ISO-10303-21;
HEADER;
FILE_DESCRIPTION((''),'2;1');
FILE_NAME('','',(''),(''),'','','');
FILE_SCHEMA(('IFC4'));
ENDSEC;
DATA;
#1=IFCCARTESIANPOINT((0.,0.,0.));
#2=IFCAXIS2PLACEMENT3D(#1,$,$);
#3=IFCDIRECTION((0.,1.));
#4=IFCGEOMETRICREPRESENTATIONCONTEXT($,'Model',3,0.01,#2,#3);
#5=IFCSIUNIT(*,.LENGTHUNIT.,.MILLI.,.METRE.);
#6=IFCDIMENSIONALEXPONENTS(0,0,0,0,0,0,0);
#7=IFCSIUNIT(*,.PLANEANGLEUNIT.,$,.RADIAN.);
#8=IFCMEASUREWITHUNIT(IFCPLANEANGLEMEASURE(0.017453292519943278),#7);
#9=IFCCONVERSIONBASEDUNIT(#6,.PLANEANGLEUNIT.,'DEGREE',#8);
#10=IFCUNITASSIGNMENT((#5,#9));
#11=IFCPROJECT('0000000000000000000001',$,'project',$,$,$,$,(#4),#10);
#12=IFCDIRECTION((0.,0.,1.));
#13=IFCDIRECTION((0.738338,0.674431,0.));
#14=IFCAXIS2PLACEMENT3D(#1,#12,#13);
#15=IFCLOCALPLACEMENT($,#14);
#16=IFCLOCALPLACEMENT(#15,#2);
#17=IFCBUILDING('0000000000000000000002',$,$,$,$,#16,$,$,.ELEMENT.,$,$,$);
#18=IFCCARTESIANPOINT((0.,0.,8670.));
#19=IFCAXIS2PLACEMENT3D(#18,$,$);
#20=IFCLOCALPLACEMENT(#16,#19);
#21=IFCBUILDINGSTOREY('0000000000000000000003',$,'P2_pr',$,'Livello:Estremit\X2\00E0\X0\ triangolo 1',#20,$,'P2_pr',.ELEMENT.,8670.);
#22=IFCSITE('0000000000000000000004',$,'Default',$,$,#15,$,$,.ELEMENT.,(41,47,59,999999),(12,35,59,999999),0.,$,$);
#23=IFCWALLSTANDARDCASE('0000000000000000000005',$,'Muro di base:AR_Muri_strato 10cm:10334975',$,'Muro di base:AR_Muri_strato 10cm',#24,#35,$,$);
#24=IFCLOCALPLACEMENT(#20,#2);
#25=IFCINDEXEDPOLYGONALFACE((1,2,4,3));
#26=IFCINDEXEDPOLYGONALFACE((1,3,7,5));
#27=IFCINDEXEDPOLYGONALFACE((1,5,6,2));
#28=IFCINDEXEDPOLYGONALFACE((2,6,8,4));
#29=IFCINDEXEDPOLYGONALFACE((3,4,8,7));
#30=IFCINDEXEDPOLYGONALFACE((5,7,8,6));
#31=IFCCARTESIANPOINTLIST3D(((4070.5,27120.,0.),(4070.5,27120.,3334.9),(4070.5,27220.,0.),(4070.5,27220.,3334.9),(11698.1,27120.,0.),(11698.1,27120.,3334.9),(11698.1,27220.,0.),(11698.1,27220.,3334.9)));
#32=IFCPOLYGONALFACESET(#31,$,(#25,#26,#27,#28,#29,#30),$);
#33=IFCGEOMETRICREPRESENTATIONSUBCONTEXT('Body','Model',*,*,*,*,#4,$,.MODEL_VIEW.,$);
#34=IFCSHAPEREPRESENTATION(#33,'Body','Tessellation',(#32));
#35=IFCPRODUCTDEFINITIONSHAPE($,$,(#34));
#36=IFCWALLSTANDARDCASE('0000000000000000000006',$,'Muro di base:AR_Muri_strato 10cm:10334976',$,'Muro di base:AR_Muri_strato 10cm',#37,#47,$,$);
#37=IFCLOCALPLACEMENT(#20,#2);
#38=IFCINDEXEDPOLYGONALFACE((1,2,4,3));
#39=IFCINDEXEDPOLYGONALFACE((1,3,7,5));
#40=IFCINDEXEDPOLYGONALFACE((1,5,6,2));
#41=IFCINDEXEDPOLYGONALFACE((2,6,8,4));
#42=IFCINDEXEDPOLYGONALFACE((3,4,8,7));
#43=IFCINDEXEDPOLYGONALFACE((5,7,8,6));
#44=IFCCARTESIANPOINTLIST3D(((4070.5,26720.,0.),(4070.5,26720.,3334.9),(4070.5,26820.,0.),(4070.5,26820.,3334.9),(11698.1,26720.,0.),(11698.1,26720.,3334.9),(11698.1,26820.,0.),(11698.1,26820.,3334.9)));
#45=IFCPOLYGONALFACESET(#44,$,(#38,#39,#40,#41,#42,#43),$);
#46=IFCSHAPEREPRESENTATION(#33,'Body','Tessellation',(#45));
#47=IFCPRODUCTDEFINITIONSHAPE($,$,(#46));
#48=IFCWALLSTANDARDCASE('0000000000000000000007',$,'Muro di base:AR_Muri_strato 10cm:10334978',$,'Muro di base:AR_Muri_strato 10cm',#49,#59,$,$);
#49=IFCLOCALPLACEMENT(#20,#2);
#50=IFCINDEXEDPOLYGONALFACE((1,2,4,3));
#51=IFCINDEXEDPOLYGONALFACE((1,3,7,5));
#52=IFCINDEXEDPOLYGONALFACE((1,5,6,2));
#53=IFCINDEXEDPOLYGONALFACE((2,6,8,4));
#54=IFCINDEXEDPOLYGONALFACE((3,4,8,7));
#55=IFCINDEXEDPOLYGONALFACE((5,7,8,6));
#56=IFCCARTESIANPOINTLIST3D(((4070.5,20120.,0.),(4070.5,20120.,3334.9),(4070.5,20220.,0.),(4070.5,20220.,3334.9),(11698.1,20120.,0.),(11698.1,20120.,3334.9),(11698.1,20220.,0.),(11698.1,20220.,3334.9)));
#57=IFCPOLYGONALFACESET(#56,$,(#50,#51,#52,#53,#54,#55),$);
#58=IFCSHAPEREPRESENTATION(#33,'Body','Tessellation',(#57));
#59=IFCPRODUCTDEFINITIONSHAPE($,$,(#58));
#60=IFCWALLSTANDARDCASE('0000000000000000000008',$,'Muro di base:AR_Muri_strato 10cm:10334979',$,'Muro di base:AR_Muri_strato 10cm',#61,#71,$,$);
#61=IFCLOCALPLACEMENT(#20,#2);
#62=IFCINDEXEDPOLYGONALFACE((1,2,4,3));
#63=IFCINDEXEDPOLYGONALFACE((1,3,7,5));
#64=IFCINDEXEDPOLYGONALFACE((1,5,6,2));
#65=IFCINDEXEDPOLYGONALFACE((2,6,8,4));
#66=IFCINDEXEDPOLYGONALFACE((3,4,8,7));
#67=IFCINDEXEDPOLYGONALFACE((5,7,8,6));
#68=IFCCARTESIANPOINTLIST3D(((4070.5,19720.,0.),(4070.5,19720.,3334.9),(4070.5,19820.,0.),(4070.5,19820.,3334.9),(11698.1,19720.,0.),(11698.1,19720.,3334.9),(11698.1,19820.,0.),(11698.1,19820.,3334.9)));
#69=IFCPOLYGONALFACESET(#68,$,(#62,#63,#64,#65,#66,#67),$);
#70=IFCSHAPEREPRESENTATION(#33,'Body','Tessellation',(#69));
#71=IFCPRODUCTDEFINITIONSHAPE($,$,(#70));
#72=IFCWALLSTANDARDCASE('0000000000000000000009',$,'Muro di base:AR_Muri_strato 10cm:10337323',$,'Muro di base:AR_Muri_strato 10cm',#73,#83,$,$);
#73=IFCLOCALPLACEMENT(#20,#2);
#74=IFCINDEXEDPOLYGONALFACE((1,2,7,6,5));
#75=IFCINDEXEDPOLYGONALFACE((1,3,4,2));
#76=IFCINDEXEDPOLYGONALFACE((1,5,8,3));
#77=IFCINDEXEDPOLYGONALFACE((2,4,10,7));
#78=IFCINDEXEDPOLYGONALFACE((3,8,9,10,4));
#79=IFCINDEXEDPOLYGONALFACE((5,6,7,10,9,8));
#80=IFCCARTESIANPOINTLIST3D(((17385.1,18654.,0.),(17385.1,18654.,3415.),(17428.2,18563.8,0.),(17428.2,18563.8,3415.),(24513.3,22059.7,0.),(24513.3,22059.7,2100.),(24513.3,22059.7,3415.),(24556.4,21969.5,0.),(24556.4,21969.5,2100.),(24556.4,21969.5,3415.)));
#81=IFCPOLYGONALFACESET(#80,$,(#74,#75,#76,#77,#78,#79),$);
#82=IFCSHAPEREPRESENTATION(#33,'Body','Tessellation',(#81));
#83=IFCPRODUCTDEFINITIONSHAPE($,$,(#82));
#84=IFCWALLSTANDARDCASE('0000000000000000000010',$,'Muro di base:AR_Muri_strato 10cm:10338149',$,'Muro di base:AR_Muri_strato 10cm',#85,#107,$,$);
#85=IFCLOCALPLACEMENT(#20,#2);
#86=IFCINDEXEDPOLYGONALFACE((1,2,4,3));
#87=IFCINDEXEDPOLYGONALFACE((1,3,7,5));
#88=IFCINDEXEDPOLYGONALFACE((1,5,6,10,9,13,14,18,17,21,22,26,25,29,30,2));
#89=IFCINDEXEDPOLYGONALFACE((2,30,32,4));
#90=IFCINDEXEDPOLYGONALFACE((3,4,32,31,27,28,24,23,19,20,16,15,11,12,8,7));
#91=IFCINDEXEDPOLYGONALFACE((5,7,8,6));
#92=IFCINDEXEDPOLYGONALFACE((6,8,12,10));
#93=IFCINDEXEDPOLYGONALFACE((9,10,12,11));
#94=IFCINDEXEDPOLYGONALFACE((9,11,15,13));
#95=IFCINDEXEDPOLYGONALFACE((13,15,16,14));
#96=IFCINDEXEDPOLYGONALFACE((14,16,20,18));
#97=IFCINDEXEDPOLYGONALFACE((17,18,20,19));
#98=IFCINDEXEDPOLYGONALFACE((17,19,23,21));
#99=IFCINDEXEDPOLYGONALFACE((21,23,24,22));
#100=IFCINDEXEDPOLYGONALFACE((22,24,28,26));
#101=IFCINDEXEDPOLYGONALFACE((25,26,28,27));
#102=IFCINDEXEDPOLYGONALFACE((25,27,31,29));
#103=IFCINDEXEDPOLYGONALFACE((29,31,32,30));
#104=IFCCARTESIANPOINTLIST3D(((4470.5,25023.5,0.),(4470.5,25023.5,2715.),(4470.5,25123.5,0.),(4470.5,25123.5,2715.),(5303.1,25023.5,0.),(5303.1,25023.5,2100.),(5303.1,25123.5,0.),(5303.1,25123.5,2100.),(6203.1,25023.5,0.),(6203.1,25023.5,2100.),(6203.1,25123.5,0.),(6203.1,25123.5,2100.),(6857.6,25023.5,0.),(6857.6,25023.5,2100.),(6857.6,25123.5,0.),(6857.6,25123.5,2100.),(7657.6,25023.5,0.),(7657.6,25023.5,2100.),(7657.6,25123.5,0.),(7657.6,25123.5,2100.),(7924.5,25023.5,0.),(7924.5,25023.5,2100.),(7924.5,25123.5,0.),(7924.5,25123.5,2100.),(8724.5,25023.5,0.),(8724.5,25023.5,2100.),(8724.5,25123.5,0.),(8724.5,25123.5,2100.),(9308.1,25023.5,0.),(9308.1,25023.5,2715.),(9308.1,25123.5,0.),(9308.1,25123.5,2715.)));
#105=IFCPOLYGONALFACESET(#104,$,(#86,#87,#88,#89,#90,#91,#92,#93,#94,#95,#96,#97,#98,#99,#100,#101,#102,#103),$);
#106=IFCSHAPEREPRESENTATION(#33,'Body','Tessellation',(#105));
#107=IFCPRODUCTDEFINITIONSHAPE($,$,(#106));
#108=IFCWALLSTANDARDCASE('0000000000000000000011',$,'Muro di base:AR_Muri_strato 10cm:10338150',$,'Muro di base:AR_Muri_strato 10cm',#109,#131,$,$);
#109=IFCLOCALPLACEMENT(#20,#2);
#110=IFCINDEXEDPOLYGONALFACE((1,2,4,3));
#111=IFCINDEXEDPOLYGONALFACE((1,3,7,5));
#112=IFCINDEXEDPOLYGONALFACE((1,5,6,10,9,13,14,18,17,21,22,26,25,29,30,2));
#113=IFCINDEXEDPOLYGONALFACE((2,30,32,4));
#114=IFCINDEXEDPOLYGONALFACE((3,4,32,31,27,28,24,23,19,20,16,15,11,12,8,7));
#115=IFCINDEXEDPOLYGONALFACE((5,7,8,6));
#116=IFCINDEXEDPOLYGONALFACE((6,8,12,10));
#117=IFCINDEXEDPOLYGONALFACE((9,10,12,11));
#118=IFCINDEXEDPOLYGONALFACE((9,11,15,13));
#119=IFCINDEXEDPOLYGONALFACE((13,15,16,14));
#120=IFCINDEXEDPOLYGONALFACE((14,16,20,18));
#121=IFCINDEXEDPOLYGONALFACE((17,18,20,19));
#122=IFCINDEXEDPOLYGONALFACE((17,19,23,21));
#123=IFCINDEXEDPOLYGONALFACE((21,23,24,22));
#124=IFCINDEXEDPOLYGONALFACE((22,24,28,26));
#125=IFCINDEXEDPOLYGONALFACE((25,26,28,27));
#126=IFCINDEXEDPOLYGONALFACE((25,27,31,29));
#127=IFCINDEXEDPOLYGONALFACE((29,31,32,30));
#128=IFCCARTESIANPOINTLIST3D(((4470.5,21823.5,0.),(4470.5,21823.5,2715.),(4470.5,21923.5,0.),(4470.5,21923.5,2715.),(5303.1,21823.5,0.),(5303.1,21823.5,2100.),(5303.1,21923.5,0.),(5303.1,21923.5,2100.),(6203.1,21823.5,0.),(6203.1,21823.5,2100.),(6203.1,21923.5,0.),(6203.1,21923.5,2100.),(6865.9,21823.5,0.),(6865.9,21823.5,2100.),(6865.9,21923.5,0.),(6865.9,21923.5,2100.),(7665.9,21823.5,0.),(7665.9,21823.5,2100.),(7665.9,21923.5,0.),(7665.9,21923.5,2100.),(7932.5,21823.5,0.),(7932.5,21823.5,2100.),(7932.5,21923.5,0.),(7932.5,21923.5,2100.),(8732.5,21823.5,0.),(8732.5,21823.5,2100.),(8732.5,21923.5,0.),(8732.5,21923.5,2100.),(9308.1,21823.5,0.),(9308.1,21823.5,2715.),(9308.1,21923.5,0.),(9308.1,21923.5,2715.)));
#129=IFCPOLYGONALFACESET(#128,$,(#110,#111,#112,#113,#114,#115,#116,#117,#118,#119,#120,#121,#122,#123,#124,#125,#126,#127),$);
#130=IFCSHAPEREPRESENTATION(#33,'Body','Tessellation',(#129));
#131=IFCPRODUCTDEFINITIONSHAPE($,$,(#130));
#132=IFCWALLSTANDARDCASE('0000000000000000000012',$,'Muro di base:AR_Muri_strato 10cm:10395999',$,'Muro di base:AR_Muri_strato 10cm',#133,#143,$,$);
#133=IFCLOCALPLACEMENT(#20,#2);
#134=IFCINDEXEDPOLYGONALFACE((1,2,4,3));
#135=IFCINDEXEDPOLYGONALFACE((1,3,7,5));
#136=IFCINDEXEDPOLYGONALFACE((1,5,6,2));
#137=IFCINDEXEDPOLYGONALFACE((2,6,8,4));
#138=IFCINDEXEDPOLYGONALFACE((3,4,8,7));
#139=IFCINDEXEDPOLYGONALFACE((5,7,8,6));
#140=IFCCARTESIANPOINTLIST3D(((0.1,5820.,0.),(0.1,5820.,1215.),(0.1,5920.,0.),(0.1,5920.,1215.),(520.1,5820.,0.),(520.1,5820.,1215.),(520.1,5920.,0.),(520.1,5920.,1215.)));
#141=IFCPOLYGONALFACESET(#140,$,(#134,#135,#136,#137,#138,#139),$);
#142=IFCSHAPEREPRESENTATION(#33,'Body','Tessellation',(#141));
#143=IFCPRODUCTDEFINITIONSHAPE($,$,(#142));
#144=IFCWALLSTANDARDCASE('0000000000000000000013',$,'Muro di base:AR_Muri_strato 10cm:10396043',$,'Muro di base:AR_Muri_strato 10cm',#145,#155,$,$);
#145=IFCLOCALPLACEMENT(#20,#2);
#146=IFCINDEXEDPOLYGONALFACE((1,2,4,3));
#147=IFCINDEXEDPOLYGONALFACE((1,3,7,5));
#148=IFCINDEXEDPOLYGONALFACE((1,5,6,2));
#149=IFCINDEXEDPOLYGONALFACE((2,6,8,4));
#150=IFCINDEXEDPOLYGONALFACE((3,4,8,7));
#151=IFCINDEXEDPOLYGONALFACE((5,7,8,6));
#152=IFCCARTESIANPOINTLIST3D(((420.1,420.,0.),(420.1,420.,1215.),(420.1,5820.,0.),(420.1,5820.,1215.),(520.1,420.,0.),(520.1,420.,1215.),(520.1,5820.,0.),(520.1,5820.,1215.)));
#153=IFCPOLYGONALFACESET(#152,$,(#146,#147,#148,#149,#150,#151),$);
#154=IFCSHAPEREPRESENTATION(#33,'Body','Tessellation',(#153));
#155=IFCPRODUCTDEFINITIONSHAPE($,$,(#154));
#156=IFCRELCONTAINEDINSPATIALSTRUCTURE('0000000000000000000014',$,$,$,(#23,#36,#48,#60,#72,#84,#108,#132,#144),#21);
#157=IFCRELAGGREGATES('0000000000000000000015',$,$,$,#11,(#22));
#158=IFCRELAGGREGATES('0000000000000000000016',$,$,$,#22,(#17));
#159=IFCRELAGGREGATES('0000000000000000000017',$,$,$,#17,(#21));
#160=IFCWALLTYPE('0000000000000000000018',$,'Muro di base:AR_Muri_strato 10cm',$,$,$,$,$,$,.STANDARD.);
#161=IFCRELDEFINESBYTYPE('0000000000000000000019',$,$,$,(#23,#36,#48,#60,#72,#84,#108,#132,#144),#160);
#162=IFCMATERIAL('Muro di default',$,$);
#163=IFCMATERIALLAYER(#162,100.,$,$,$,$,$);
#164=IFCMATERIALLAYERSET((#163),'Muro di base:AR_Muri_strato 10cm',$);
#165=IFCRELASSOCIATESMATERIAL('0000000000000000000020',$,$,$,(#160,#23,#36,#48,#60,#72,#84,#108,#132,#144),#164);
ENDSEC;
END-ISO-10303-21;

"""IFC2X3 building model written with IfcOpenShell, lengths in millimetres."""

from ifc_helpers import new_model, entity, si_unit, converted_unit, direction, frame, frame_2d, origin, origin_2d_with_axis, place, context, subcontext, project, spatial, rectangle, extrude, material, layer, layer_set, layer_usage, type_object, element, save


model = new_model("IFC2X3")

# Units and contexts
model_context = context("Model", 3, precision=0.01, world=origin(), true_north=direction((0.0, 1.0)))
body_context = subcontext(model_context, "Body", "Model", "MODEL_VIEW")
ifc_project = project(units=[si_unit("LENGTHUNIT", "METRE", prefix="MILLI"), converted_unit("PLANEANGLEUNIT", "DEGREE", entity("IfcPlaneAngleMeasure", 0.017453292519943278), si_unit("PLANEANGLEUNIT", "RADIAN"), dimensions=[0, 0, 0, 0, 0, 0, 0])], contexts=[model_context])

# Site, building, storey
site_placement = place(None, frame((0.0, 0.0, 0.0), z_axis=(0.0, 0.0, 1.0), x_axis=(0.738338, 0.674431, 0.0)))
site = spatial("IfcSite", under=ifc_project, at=site_placement, Name="Default", CompositionType="ELEMENT", RefLatitude=(41, 47, 59, 999999), RefLongitude=(12, 35, 59, 999999), RefElevation=0.0)
building_placement = place(site_placement, origin())
building = spatial("IfcBuilding", under=site, at=building_placement, CompositionType="ELEMENT")
storey_placement = place(building_placement, frame((0.0, 0.0, 8670.0)))
storey = spatial("IfcBuildingStorey", under=building, at=storey_placement, Name="P2_pr", ObjectType="Livello:Estremità triangolo 1", LongName="P2_pr", CompositionType="ELEMENT", Elevation=8670.0)

# Walls
ifc_material = material(Name="Muro di default")
ifc_layer_1 = layer(ifc_material, 100.0)
ifc_layer_set_1 = layer_set([ifc_layer_1], Name="Muro di base:AR_Muri_strato 10cm")
ifc_layer_usage_1 = layer_usage(ifc_layer_set_1, "AXIS2", "NEGATIVE", 50.0)
wall_type_1 = type_object("IfcWallType", Name="Muro di base:AR_Muri_strato 10cm", PredefinedType="STANDARD", material=ifc_layer_set_1)
wall_1_placement = place(storey_placement, frame((4070.5, 27170.0, 0.0)))
element("IfcWallStandardCase", 1, at=wall_1_placement, inside=storey, type_object=wall_type_1, material=ifc_layer_usage_1, Name="Muro di base:AR_Muri_strato 10cm:10334975", ObjectType="Muro di base:AR_Muri_strato 10cm", context=body_context, shape_type="SweptSolid", body=[
    extrude(rectangle(XDim=7627.6, YDim=100.0, at=frame_2d((3813.8, 0.0), x_axis=(-1.0, 0.0))), origin(), (0.0, 0.0, 1.0), 3334.9),
])
ifc_layer_usage_2 = layer_usage(ifc_layer_set_1, "AXIS2", "POSITIVE", -50.0)
wall_2_placement = place(storey_placement, frame((4070.5, 26770.0, 0.0)))
element("IfcWallStandardCase", 2, at=wall_2_placement, inside=storey, type_object=wall_type_1, material=ifc_layer_usage_2, Name="Muro di base:AR_Muri_strato 10cm:10334976", ObjectType="Muro di base:AR_Muri_strato 10cm", context=body_context, shape_type="SweptSolid", body=[
    extrude(rectangle(XDim=7627.6, YDim=100.0, at=frame_2d((3813.8, 0.0), x_axis=(-1.0, 0.0))), origin(), (0.0, 0.0, 1.0), 3334.9),
])
ifc_layer_usage_3 = layer_usage(ifc_layer_set_1, "AXIS2", "NEGATIVE", 50.0)
wall_3_placement = place(storey_placement, frame((4070.5, 20170.0, 0.0)))
element("IfcWallStandardCase", 3, at=wall_3_placement, inside=storey, type_object=wall_type_1, material=ifc_layer_usage_3, Name="Muro di base:AR_Muri_strato 10cm:10334978", ObjectType="Muro di base:AR_Muri_strato 10cm", context=body_context, shape_type="SweptSolid", body=[
    extrude(rectangle(XDim=7627.6, YDim=100.0, at=frame_2d((3813.8, 0.0), x_axis=(-1.0, 0.0))), origin(), (0.0, 0.0, 1.0), 3334.9),
])
ifc_layer_usage_4 = layer_usage(ifc_layer_set_1, "AXIS2", "POSITIVE", -50.0)
wall_4_placement = place(storey_placement, frame((4070.5, 19770.0, 0.0)))
element("IfcWallStandardCase", 4, at=wall_4_placement, inside=storey, type_object=wall_type_1, material=ifc_layer_usage_4, Name="Muro di base:AR_Muri_strato 10cm:10334979", ObjectType="Muro di base:AR_Muri_strato 10cm", context=body_context, shape_type="SweptSolid", body=[
    extrude(rectangle(XDim=7627.6, YDim=100.0, at=frame_2d((3813.8, 0.0), x_axis=(-1.0, 0.0))), origin(), (0.0, 0.0, 1.0), 3334.9),
])

# Wall, opening
ifc_layer_usage_5 = layer_usage(ifc_layer_set_1, "AXIS2", "POSITIVE", -50.0)
wall_5_placement = place(storey_placement, frame((24534.8, 22014.6, 0.0), z_axis=(0.0, 0.0, 1.0), x_axis=(-0.902302, -0.431105, 0.0)))
wall_5 = element("IfcWallStandardCase", 5, at=wall_5_placement, inside=storey, type_object=wall_type_1, material=ifc_layer_usage_5, Name="Muro di base:AR_Muri_strato 10cm:10337323", ObjectType="Muro di base:AR_Muri_strato 10cm", context=body_context, shape_type="SweptSolid", body=[
    extrude(rectangle(XDim=7900.0, YDim=100.0, at=frame_2d((3950.0, 0.0), x_axis=(-1.0, 0.0))), origin(), (0.0, 0.0, 1.0), 3415.0),
])
opening_1_placement = place(wall_5_placement, origin())
element("IfcOpeningElement", 6, at=opening_1_placement, cuts=wall_5, ObjectType="Opening", context=body_context, shape_type="SweptSolid", body=[
    extrude(rectangle(XDim=2100.0, YDim=1100.0, at=frame_2d((0.0, 0.0), x_axis=(0.0, 1.0))), frame((-550.0, -1874.0, 1050.0), z_axis=(0.000006, 1.0, 0.0), x_axis=(1.0, -0.000006, 0.0)), (0.0, 0.0, 1.0), 3048.0),
])

# Walls, openings
ifc_layer_usage_6 = layer_usage(ifc_layer_set_1, "AXIS2", "NEGATIVE", 50.0)
wall_6_placement = place(storey_placement, frame((4470.5, 25073.5, 0.0)))
wall_6 = element("IfcWallStandardCase", 7, at=wall_6_placement, inside=storey, type_object=wall_type_1, material=ifc_layer_usage_6, Name="Muro di base:AR_Muri_strato 10cm:10338149", ObjectType="Muro di base:AR_Muri_strato 10cm", context=body_context, shape_type="SweptSolid", body=[
    extrude(rectangle(XDim=4837.6, YDim=100.0, at=frame_2d((2418.8, 0.0), x_axis=(-1.0, 0.0))), origin(), (0.0, 0.0, 1.0), 2715.0),
])
opening_2_placement = place(wall_6_placement, frame((-4470.5, -25073.5, 0.0)))
element("IfcOpeningElement", 8, at=opening_2_placement, cuts=wall_6, ObjectType="Opening", context=body_context, shape_type="SweptSolid", body=[
    extrude(rectangle(XDim=2100.0, YDim=800.0, at=frame_2d((0.0, 0.0), x_axis=(0.0, 1.0))), frame((7257.6, 23499.5, 1050.0), z_axis=(0.0, 1.0, 0.0), x_axis=(1.0, 0.0, 0.0)), (0.0, 0.0, 1.0), 3048.0),
])
opening_3_placement = place(wall_6_placement, frame((-4470.5, -25073.5, 0.0)))
element("IfcOpeningElement", 9, at=opening_3_placement, cuts=wall_6, ObjectType="Opening", context=body_context, shape_type="SweptSolid", body=[
    extrude(rectangle(XDim=2100.0, YDim=800.0, at=origin_2d_with_axis()), frame((8324.5, 23599.5, 1050.0), z_axis=(0.0, 1.0, 0.0), x_axis=(0.0, 0.0, -1.0)), (0.0, 0.0, 1.0), 3048.0),
])
opening_4_placement = place(wall_6_placement, frame((-4470.5, -25073.5, 0.0)))
element("IfcOpeningElement", 10, at=opening_4_placement, cuts=wall_6, ObjectType="Opening", context=body_context, shape_type="SweptSolid", body=[
    extrude(rectangle(XDim=2100.0, YDim=900.0, at=origin_2d_with_axis()), frame((5753.1, 23599.5, 1050.0), z_axis=(0.0, 1.0, 0.0), x_axis=(0.0, 0.0, -1.0)), (0.0, 0.0, 1.0), 3048.0),
])
ifc_layer_usage_7 = layer_usage(ifc_layer_set_1, "AXIS2", "POSITIVE", -50.0)
wall_7_placement = place(storey_placement, frame((4470.5, 21873.5, 0.0)))
wall_7 = element("IfcWallStandardCase", 11, at=wall_7_placement, inside=storey, type_object=wall_type_1, material=ifc_layer_usage_7, Name="Muro di base:AR_Muri_strato 10cm:10338150", ObjectType="Muro di base:AR_Muri_strato 10cm", context=body_context, shape_type="SweptSolid", body=[
    extrude(rectangle(XDim=4837.6, YDim=100.0, at=frame_2d((2418.8, 0.0), x_axis=(-1.0, 0.0))), origin(), (0.0, 0.0, 1.0), 2715.0),
])
opening_5_placement = place(wall_7_placement, frame((-4470.5, -21873.5, 0.0)))
element("IfcOpeningElement", 12, at=opening_5_placement, cuts=wall_7, ObjectType="Opening", context=body_context, shape_type="SweptSolid", body=[
    extrude(rectangle(XDim=2100.0, YDim=800.0, at=frame_2d((0.0, 0.0), x_axis=(0.0, 1.0))), frame((7265.9, 20299.5, 1050.0), z_axis=(0.0, 1.0, 0.0), x_axis=(1.0, 0.0, 0.0)), (0.0, 0.0, 1.0), 3048.0),
])
opening_6_placement = place(wall_7_placement, frame((-4470.5, -21873.5, 0.0)))
element("IfcOpeningElement", 13, at=opening_6_placement, cuts=wall_7, ObjectType="Opening", context=body_context, shape_type="SweptSolid", body=[
    extrude(rectangle(XDim=2100.0, YDim=800.0, at=origin_2d_with_axis()), frame((8332.5, 20399.5, 1050.0), z_axis=(0.0, 1.0, 0.0), x_axis=(0.0, 0.0, -1.0)), (0.0, 0.0, 1.0), 3048.0),
])
opening_7_placement = place(wall_7_placement, frame((-4470.5, -21873.5, 0.0)))
element("IfcOpeningElement", 14, at=opening_7_placement, cuts=wall_7, ObjectType="Opening", context=body_context, shape_type="SweptSolid", body=[
    extrude(rectangle(XDim=2100.0, YDim=900.0, at=origin_2d_with_axis()), frame((5753.1, 20399.5, 1050.0), z_axis=(0.0, 1.0, 0.0), x_axis=(0.0, 0.0, -1.0)), (0.0, 0.0, 1.0), 3048.0),
])

# Walls
ifc_layer_usage_8 = layer_usage(ifc_layer_set_1, "AXIS2", "NEGATIVE", 50.0)
wall_8_placement = place(storey_placement, frame((0.1, 5870.0, 0.0)))
element("IfcWallStandardCase", 15, at=wall_8_placement, inside=storey, type_object=wall_type_1, material=ifc_layer_usage_8, Name="Muro di base:AR_Muri_strato 10cm:10395999", ObjectType="Muro di base:AR_Muri_strato 10cm", context=body_context, shape_type="SweptSolid", body=[
    extrude(rectangle(XDim=520.0, YDim=100.0, at=frame_2d((260.0, 0.0), x_axis=(-1.0, 0.0))), origin(), (0.0, 0.0, 1.0), 1215.0),
])
ifc_layer_usage_9 = layer_usage(ifc_layer_set_1, "AXIS2", "NEGATIVE", 50.0)
wall_9_placement = place(storey_placement, frame((470.1, 5820.0, 0.0), z_axis=(0.0, 0.0, 1.0), x_axis=(0.0, -1.0, 0.0)))
element("IfcWallStandardCase", 16, at=wall_9_placement, inside=storey, type_object=wall_type_1, material=ifc_layer_usage_9, Name="Muro di base:AR_Muri_strato 10cm:10396043", ObjectType="Muro di base:AR_Muri_strato 10cm", context=body_context, shape_type="SweptSolid", body=[
    extrude(rectangle(XDim=5400.0, YDim=100.0, at=frame_2d((2700.0, 0.0), x_axis=(-1.0, 0.0))), origin(), (0.0, 0.0, 1.0), 1215.0),
])

save(model, "model.ifc")
